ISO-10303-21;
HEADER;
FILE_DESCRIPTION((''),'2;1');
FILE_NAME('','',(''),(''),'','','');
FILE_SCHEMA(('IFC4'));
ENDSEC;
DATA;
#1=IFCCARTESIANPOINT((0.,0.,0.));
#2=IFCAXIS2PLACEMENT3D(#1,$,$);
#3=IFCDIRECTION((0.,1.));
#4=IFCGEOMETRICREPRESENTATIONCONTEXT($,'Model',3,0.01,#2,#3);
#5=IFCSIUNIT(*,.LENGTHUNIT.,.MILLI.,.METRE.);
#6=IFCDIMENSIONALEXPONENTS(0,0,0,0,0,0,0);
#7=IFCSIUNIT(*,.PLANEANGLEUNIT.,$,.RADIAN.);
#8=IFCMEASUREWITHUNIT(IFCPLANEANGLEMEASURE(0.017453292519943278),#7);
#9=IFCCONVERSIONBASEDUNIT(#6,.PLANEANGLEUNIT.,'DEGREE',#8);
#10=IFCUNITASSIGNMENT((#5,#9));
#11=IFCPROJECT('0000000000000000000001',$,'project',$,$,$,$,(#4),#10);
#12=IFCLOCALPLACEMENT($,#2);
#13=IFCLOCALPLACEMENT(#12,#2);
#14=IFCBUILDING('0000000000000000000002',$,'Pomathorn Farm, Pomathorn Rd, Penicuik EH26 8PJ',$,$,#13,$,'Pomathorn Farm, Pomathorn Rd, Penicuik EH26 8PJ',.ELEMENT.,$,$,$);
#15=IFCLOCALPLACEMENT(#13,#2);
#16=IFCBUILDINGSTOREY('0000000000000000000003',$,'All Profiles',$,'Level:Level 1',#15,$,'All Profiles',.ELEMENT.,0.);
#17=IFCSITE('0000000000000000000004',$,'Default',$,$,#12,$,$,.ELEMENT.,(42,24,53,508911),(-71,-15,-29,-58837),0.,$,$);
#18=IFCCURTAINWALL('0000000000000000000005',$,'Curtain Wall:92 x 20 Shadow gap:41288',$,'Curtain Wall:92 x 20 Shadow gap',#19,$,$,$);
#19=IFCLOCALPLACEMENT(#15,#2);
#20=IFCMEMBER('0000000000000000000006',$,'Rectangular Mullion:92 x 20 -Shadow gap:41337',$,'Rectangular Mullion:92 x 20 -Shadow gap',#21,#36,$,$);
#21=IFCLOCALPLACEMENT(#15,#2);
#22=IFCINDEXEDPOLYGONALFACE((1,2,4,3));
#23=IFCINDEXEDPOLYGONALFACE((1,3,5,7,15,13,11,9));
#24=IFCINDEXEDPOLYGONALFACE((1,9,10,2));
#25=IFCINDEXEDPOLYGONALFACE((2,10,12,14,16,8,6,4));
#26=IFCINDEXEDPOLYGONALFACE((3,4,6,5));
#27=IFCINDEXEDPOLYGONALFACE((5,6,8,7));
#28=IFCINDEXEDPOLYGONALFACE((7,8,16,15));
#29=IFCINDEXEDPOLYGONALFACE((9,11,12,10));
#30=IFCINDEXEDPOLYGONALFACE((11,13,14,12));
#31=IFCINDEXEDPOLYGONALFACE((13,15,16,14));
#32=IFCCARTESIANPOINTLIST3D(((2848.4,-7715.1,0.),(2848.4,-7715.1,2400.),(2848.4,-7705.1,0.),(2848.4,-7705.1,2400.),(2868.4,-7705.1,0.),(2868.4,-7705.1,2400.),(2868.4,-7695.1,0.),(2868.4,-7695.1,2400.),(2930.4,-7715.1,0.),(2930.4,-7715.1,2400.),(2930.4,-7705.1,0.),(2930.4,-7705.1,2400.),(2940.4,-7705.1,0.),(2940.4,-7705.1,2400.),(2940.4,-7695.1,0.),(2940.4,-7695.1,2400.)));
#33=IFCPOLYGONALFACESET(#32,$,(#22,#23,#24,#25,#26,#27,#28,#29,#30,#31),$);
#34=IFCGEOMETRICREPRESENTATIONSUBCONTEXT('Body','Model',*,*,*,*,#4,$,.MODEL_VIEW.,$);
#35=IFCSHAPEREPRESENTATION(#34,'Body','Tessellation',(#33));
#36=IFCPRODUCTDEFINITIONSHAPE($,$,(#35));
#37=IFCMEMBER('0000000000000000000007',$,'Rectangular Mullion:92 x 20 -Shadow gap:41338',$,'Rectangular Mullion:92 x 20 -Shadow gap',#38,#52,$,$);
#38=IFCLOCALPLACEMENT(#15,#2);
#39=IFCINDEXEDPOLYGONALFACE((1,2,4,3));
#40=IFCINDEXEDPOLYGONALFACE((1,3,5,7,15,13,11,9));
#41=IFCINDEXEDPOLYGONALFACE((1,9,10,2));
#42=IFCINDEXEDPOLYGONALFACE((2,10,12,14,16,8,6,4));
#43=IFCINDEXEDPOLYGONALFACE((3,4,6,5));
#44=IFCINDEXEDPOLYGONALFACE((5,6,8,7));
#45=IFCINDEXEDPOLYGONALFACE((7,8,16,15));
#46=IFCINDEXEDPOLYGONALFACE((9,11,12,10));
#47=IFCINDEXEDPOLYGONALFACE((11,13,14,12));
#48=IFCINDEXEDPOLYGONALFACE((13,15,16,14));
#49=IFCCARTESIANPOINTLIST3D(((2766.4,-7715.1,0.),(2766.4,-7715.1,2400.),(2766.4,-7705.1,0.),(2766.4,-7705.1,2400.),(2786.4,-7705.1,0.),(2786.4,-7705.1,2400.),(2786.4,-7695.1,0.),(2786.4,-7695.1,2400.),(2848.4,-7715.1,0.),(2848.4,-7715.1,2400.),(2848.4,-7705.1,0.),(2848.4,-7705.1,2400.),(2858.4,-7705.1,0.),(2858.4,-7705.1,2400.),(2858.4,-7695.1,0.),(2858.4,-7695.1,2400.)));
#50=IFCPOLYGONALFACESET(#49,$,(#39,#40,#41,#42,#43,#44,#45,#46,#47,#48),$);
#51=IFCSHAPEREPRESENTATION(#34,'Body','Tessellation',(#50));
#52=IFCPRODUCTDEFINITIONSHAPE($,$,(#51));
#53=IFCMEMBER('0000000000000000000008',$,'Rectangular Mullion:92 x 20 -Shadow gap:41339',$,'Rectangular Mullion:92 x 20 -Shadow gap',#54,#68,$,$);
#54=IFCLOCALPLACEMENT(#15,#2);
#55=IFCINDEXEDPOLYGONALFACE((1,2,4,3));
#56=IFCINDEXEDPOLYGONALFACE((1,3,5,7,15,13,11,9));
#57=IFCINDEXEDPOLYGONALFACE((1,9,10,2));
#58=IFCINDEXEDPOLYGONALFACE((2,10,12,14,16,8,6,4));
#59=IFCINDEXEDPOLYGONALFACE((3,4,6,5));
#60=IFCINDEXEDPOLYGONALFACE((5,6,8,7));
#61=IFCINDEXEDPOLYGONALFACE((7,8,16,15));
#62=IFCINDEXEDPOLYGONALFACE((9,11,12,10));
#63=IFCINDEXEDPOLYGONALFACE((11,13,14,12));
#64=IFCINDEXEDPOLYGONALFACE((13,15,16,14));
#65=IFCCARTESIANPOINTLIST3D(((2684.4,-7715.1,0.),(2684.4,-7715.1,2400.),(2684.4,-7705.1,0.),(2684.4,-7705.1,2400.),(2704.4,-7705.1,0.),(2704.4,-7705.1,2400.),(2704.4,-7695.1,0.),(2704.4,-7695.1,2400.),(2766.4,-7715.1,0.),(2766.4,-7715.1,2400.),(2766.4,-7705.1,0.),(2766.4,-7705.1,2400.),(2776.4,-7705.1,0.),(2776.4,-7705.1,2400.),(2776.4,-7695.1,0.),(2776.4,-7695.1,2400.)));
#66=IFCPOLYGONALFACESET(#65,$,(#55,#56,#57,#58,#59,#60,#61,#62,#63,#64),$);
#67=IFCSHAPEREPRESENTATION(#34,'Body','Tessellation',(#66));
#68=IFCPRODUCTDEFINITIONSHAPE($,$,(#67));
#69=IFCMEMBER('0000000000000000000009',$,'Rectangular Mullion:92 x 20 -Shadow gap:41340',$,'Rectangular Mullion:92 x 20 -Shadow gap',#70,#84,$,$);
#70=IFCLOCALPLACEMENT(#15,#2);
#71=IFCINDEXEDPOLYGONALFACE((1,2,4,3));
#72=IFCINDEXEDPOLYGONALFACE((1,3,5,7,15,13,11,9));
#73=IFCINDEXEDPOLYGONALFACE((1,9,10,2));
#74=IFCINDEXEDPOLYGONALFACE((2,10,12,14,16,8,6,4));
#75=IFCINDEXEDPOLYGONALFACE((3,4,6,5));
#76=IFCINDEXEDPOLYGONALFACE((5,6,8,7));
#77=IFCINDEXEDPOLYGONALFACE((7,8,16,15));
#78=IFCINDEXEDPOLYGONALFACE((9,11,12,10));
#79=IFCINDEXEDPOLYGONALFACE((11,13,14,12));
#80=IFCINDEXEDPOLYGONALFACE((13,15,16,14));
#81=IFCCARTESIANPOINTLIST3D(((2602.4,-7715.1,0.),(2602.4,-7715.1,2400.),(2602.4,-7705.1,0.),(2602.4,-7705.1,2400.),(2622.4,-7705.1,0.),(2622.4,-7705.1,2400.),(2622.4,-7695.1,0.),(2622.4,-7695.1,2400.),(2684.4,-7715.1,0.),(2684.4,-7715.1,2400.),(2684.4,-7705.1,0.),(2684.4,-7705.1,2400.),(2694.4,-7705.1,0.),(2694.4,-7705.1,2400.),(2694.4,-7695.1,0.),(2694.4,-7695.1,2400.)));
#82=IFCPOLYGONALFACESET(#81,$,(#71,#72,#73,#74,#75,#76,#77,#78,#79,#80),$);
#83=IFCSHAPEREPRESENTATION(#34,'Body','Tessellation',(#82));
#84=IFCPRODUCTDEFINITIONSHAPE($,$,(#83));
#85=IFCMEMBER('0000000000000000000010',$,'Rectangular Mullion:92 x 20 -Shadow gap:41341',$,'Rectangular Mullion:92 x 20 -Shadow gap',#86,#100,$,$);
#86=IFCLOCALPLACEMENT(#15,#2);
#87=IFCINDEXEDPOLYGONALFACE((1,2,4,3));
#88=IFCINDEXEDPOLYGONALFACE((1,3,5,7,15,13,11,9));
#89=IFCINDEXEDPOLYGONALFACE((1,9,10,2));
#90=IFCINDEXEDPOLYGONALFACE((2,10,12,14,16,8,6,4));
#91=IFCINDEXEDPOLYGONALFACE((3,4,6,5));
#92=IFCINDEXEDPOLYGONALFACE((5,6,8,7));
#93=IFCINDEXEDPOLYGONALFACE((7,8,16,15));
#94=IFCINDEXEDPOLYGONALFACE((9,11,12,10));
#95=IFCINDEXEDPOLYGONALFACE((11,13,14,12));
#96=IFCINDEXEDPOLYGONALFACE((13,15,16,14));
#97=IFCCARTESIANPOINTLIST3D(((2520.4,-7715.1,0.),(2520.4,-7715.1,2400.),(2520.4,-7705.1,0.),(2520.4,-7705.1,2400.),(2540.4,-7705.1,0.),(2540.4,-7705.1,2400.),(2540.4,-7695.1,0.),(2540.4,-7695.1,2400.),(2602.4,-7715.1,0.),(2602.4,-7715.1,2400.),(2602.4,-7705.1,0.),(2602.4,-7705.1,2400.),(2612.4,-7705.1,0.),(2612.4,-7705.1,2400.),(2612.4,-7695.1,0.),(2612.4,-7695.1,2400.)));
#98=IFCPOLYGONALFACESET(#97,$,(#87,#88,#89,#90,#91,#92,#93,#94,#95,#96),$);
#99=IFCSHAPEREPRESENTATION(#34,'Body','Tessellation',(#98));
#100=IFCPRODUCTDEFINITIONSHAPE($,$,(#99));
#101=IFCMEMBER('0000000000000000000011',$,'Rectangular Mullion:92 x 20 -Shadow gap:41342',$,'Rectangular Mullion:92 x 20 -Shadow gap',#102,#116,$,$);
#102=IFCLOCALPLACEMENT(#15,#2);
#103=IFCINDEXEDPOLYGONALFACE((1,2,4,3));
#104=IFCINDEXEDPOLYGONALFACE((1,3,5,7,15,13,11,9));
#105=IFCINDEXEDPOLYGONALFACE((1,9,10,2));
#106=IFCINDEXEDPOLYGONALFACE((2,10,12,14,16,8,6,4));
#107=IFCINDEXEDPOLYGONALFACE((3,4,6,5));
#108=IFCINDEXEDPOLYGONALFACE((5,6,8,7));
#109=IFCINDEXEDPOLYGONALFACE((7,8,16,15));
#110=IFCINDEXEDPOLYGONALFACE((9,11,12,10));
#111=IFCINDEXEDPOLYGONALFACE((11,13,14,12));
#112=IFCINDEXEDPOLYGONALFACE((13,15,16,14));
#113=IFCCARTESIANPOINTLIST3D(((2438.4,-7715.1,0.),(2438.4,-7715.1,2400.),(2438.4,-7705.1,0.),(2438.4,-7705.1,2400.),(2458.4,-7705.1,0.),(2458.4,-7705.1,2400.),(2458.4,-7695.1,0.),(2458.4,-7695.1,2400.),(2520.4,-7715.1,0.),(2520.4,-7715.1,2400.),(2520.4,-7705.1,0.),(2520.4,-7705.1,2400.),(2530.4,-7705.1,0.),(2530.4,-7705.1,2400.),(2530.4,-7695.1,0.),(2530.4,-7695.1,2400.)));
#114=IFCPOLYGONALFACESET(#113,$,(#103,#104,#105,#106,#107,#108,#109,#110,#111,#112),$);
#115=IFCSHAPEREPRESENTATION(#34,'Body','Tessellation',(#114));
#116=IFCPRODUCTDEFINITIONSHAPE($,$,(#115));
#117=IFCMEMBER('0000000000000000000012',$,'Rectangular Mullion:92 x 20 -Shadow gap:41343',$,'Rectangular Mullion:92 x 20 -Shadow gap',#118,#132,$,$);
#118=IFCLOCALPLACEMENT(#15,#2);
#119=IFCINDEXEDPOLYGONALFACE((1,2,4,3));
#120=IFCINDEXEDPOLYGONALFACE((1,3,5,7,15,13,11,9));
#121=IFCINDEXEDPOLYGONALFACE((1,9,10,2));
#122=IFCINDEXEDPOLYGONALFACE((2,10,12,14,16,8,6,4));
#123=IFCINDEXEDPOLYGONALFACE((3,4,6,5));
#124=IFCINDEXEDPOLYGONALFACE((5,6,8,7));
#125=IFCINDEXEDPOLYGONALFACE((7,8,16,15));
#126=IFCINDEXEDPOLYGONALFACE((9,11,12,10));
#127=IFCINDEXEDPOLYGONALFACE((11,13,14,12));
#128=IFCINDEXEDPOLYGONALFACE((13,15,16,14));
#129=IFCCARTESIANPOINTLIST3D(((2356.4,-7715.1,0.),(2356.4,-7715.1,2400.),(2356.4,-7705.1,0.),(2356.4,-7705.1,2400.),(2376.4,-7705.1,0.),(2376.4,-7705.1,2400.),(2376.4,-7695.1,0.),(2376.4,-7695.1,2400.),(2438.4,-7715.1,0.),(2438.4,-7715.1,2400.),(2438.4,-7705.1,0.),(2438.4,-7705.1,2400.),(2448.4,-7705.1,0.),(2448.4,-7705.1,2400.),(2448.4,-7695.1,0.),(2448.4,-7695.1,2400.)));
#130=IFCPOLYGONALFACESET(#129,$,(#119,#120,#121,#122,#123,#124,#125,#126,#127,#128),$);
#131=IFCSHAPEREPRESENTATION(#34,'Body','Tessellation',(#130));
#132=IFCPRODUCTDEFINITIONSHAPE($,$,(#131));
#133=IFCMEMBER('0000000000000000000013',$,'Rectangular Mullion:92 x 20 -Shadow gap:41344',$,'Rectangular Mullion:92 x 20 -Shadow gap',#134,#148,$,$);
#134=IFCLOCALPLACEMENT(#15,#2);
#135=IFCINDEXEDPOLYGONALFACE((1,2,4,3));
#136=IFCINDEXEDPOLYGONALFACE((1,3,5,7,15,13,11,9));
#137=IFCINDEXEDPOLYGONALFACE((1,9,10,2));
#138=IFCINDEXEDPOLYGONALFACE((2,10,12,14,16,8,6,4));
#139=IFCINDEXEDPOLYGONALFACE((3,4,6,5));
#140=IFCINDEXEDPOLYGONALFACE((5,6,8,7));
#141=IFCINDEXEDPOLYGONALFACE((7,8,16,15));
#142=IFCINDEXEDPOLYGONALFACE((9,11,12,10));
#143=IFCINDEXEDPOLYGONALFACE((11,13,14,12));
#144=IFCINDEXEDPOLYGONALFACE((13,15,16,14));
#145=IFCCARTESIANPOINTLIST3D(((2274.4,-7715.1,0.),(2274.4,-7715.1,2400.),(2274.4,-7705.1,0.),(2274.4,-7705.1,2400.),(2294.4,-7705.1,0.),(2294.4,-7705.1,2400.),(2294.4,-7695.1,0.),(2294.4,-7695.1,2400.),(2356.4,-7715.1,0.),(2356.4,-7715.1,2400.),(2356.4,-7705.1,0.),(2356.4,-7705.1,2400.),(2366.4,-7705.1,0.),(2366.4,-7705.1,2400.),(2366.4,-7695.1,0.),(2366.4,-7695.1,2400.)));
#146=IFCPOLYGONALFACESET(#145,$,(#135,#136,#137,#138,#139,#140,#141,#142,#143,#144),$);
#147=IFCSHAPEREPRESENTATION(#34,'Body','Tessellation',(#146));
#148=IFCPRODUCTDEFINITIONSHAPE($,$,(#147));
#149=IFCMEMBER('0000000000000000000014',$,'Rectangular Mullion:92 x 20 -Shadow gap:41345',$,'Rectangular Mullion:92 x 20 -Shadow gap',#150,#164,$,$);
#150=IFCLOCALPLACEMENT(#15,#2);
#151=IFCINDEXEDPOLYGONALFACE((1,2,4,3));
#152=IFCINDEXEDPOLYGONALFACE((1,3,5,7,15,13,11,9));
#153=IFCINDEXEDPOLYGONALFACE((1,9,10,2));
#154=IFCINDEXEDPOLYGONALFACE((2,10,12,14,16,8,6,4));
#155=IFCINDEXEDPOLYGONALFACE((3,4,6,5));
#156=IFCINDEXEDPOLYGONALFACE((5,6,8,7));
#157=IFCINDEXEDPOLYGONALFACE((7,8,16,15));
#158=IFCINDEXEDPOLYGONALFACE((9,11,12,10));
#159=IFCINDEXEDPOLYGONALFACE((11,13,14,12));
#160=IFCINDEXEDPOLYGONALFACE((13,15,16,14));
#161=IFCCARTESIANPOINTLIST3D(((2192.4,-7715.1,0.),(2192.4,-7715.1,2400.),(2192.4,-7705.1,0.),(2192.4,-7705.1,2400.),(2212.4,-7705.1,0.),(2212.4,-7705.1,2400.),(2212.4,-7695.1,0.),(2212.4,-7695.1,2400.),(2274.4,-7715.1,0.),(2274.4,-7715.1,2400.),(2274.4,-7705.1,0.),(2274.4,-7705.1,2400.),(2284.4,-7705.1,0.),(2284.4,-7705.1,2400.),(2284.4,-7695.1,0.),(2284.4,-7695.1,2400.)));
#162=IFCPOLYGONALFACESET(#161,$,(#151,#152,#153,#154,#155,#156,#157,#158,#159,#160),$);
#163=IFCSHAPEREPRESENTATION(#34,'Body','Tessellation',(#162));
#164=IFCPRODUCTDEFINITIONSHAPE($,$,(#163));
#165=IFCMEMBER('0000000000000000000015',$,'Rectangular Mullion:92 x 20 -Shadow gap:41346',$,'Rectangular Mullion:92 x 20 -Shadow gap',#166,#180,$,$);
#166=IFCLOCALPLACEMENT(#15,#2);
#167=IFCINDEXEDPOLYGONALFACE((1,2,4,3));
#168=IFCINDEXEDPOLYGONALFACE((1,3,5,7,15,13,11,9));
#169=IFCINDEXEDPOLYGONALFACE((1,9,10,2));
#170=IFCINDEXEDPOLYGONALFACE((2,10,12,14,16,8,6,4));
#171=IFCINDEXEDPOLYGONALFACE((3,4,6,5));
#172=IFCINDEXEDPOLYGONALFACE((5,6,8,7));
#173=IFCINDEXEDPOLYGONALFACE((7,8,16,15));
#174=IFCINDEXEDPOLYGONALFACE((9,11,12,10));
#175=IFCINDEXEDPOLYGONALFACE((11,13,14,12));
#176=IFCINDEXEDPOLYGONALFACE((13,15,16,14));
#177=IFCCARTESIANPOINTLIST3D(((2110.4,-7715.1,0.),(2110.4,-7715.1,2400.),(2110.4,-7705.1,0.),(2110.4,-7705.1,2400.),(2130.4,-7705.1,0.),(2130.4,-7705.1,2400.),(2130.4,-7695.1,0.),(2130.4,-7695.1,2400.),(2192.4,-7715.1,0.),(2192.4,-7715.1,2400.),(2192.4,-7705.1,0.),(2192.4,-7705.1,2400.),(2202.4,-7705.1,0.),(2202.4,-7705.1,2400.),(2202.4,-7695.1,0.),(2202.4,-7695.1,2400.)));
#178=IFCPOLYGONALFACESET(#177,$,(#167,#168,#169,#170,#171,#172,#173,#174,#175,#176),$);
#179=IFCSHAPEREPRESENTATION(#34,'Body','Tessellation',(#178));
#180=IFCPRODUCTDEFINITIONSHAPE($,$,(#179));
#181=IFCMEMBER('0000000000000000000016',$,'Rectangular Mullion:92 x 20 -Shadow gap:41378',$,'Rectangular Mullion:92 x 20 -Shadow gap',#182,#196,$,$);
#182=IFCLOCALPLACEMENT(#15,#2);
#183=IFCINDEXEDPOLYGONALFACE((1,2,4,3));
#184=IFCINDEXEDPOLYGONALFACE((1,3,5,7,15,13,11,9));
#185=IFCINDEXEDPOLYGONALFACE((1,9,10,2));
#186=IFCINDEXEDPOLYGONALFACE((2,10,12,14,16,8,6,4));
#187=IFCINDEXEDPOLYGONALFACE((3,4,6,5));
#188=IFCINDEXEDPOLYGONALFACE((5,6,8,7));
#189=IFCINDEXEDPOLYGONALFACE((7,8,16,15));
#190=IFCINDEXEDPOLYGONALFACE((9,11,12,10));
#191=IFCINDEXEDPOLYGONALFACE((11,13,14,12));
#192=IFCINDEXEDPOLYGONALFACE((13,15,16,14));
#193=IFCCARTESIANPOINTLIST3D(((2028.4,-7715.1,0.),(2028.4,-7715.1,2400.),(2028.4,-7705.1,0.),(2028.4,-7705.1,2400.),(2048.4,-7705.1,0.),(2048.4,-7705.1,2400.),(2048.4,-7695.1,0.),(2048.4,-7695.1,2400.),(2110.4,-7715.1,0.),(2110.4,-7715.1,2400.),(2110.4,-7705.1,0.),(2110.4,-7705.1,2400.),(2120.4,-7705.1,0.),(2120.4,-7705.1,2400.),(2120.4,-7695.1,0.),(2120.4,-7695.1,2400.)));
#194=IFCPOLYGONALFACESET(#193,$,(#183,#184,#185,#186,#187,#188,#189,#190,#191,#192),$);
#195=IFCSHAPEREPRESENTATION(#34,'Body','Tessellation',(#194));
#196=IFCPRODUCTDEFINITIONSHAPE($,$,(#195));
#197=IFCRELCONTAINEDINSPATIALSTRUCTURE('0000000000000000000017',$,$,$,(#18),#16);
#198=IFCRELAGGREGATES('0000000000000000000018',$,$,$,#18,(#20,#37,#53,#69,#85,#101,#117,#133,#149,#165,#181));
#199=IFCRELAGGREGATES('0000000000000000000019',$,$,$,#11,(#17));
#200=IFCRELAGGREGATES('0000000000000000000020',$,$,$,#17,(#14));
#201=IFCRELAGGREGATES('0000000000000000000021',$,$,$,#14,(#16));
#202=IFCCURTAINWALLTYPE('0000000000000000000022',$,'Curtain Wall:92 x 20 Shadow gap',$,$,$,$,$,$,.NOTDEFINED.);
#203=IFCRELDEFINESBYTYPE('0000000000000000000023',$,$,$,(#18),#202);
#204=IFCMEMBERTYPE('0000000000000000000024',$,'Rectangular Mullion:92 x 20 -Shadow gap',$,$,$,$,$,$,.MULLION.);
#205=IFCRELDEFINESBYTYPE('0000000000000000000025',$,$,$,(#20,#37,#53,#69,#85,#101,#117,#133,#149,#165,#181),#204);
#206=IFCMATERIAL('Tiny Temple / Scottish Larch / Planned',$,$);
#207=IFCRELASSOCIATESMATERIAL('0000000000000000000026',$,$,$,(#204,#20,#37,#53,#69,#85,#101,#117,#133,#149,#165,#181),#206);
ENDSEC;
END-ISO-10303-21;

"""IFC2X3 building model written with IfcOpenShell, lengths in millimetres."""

from ifc_helpers import new_model, entity, si_unit, converted_unit, direction, frame, origin, place, context, subcontext, project, spatial, polyline, outline, extrude, source, transform, mapped, material, type_object, type_shapes, element, aggregate, save


model = new_model("IFC2X3")

# Units and contexts
model_context = context("Model", 3, precision=0.01, world=origin(), true_north=direction((0.0, 1.0)))
body_context = subcontext(model_context, "Body", "Model", "MODEL_VIEW")
ifc_project = project(units=[si_unit("LENGTHUNIT", "METRE", prefix="MILLI"), converted_unit("PLANEANGLEUNIT", "DEGREE", entity("IfcPlaneAngleMeasure", 0.017453292519943278), si_unit("PLANEANGLEUNIT", "RADIAN"), dimensions=[0, 0, 0, 0, 0, 0, 0])], contexts=[model_context])

# Site, building, storey
site_placement = place(None, origin())
site = spatial("IfcSite", under=ifc_project, at=site_placement, Name="Default", CompositionType="ELEMENT", RefLatitude=(42, 24, 53, 508911), RefLongitude=(-71, -15, -29, -58837), RefElevation=0.0)
building_placement = place(site_placement, origin())
building = spatial("IfcBuilding", under=site, at=building_placement, Name="Pomathorn Farm, Pomathorn Rd, Penicuik EH26 8PJ", LongName="Pomathorn Farm, Pomathorn Rd, Penicuik EH26 8PJ", CompositionType="ELEMENT")
storey_placement = place(building_placement, origin())
storey = spatial("IfcBuildingStorey", under=building, at=storey_placement, Name="All Profiles", ObjectType="Level:Level 1", LongName="All Profiles", CompositionType="ELEMENT", Elevation=0.0)

# Curtain wall, members
curtain_wall_type_1 = type_object("IfcCurtainWallType", Name="Curtain Wall:92 x 20 Shadow gap", PredefinedType="NOTDEFINED")
curtain_wall_1_placement = place(storey_placement, origin())
curtain_wall_1 = element("IfcCurtainWall", 1, at=curtain_wall_1_placement, inside=storey, type_object=curtain_wall_type_1, Name="Curtain Wall:92 x 20 Shadow gap:41288", ObjectType="Curtain Wall:92 x 20 Shadow gap")
ifc_material = material(Name="Tiny Temple / Scottish Larch / Planned")
member_type_1 = type_object("IfcMemberType", Name="Rectangular Mullion:92 x 20 -Shadow gap", PredefinedType="MULLION", material=ifc_material)
shared_shape_1 = source(origin(), body_context, "Body", "SweptSolid", [
    extrude(outline(polyline([(-48.5, 0.0), (-48.5, -10.0), (33.5, -10.0), (33.5, 0.0), (43.5, 0.0), (43.5, 10.0), (-28.5, 10.0), (-28.5, 0.0), (-48.5, 0.0)])), frame((-43.5, -10.0, -2400.0), z_axis=(0.0, 0.0, -1.0), x_axis=(1.0, 0.0, 0.0)), (0.0, 0.0, -1.0), 2400.0),
])
type_shapes(member_type_1, [shared_shape_1])
member_1_placement = place(curtain_wall_1_placement, frame((2940.4, -7715.1, 0.0), z_axis=(0.0, 0.0, -1.0), x_axis=(1.0, 0.0, 0.0)))
member_1 = element("IfcMember", 2, at=member_1_placement, type_object=member_type_1, material=ifc_material, Name="Rectangular Mullion:92 x 20 -Shadow gap:41337", ObjectType="Rectangular Mullion:92 x 20 -Shadow gap", context=body_context, shape_type="MappedRepresentation", body=[
    mapped(shared_shape_1, transform((0.0, 0.0, 0.0), scale=1.0)),
])
member_2_placement = place(curtain_wall_1_placement, frame((2858.4, -7715.1, 0.0), z_axis=(0.0, 0.0, -1.0), x_axis=(1.0, 0.0, 0.0)))
member_2 = element("IfcMember", 3, at=member_2_placement, type_object=member_type_1, material=ifc_material, Name="Rectangular Mullion:92 x 20 -Shadow gap:41338", ObjectType="Rectangular Mullion:92 x 20 -Shadow gap", context=body_context, shape_type="MappedRepresentation", body=[
    mapped(shared_shape_1, transform((0.0, 0.0, 0.0), scale=1.0)),
])
member_3_placement = place(curtain_wall_1_placement, frame((2776.4, -7715.1, 0.0), z_axis=(0.0, 0.0, -1.0), x_axis=(1.0, 0.0, 0.0)))
member_3 = element("IfcMember", 4, at=member_3_placement, type_object=member_type_1, material=ifc_material, Name="Rectangular Mullion:92 x 20 -Shadow gap:41339", ObjectType="Rectangular Mullion:92 x 20 -Shadow gap", context=body_context, shape_type="MappedRepresentation", body=[
    mapped(shared_shape_1, transform((0.0, 0.0, 0.0), scale=1.0)),
])
member_4_placement = place(curtain_wall_1_placement, frame((2694.4, -7715.1, 0.0), z_axis=(0.0, 0.0, -1.0), x_axis=(1.0, 0.0, 0.0)))
member_4 = element("IfcMember", 5, at=member_4_placement, type_object=member_type_1, material=ifc_material, Name="Rectangular Mullion:92 x 20 -Shadow gap:41340", ObjectType="Rectangular Mullion:92 x 20 -Shadow gap", context=body_context, shape_type="MappedRepresentation", body=[
    mapped(shared_shape_1, transform((0.0, 0.0, 0.0), scale=1.0)),
])
member_5_placement = place(curtain_wall_1_placement, frame((2612.4, -7715.1, 0.0), z_axis=(0.0, 0.0, -1.0), x_axis=(1.0, 0.0, 0.0)))
member_5 = element("IfcMember", 6, at=member_5_placement, type_object=member_type_1, material=ifc_material, Name="Rectangular Mullion:92 x 20 -Shadow gap:41341", ObjectType="Rectangular Mullion:92 x 20 -Shadow gap", context=body_context, shape_type="MappedRepresentation", body=[
    mapped(shared_shape_1, transform((0.0, 0.0, 0.0), scale=1.0)),
])
member_6_placement = place(curtain_wall_1_placement, frame((2530.4, -7715.1, 0.0), z_axis=(0.0, 0.0, -1.0), x_axis=(1.0, 0.0, 0.0)))
member_6 = element("IfcMember", 7, at=member_6_placement, type_object=member_type_1, material=ifc_material, Name="Rectangular Mullion:92 x 20 -Shadow gap:41342", ObjectType="Rectangular Mullion:92 x 20 -Shadow gap", context=body_context, shape_type="MappedRepresentation", body=[
    mapped(shared_shape_1, transform((0.0, 0.0, 0.0), scale=1.0)),
])
member_7_placement = place(curtain_wall_1_placement, frame((2448.4, -7715.1, 0.0), z_axis=(0.0, 0.0, -1.0), x_axis=(1.0, 0.0, 0.0)))
member_7 = element("IfcMember", 8, at=member_7_placement, type_object=member_type_1, material=ifc_material, Name="Rectangular Mullion:92 x 20 -Shadow gap:41343", ObjectType="Rectangular Mullion:92 x 20 -Shadow gap", context=body_context, shape_type="MappedRepresentation", body=[
    mapped(shared_shape_1, transform((0.0, 0.0, 0.0), scale=1.0)),
])
member_8_placement = place(curtain_wall_1_placement, frame((2366.4, -7715.1, 0.0), z_axis=(0.0, 0.0, -1.0), x_axis=(1.0, 0.0, 0.0)))
member_8 = element("IfcMember", 9, at=member_8_placement, type_object=member_type_1, material=ifc_material, Name="Rectangular Mullion:92 x 20 -Shadow gap:41344", ObjectType="Rectangular Mullion:92 x 20 -Shadow gap", context=body_context, shape_type="MappedRepresentation", body=[
    mapped(shared_shape_1, transform((0.0, 0.0, 0.0), scale=1.0)),
])
member_9_placement = place(curtain_wall_1_placement, frame((2284.4, -7715.1, 0.0), z_axis=(0.0, 0.0, -1.0), x_axis=(1.0, 0.0, 0.0)))
member_9 = element("IfcMember", 10, at=member_9_placement, type_object=member_type_1, material=ifc_material, Name="Rectangular Mullion:92 x 20 -Shadow gap:41345", ObjectType="Rectangular Mullion:92 x 20 -Shadow gap", context=body_context, shape_type="MappedRepresentation", body=[
    mapped(shared_shape_1, transform((0.0, 0.0, 0.0), scale=1.0)),
])
member_10_placement = place(curtain_wall_1_placement, frame((2202.4, -7715.1, 0.0), z_axis=(0.0, 0.0, -1.0), x_axis=(1.0, 0.0, 0.0)))
member_10 = element("IfcMember", 11, at=member_10_placement, type_object=member_type_1, material=ifc_material, Name="Rectangular Mullion:92 x 20 -Shadow gap:41346", ObjectType="Rectangular Mullion:92 x 20 -Shadow gap", context=body_context, shape_type="MappedRepresentation", body=[
    mapped(shared_shape_1, transform((0.0, 0.0, 0.0), scale=1.0)),
])
member_11_placement = place(curtain_wall_1_placement, frame((2120.4, -7715.1, 0.0), z_axis=(0.0, 0.0, -1.0), x_axis=(1.0, 0.0, 0.0)))
member_11 = element("IfcMember", 12, at=member_11_placement, type_object=member_type_1, material=ifc_material, Name="Rectangular Mullion:92 x 20 -Shadow gap:41378", ObjectType="Rectangular Mullion:92 x 20 -Shadow gap", context=body_context, shape_type="MappedRepresentation", body=[
    mapped(shared_shape_1, transform((0.0, 0.0, 0.0), scale=1.0)),
])
aggregate(curtain_wall_1, [member_1, member_2, member_3, member_4, member_5, member_6, member_7, member_8, member_9, member_10, member_11])

save(model, "model.ifc")
